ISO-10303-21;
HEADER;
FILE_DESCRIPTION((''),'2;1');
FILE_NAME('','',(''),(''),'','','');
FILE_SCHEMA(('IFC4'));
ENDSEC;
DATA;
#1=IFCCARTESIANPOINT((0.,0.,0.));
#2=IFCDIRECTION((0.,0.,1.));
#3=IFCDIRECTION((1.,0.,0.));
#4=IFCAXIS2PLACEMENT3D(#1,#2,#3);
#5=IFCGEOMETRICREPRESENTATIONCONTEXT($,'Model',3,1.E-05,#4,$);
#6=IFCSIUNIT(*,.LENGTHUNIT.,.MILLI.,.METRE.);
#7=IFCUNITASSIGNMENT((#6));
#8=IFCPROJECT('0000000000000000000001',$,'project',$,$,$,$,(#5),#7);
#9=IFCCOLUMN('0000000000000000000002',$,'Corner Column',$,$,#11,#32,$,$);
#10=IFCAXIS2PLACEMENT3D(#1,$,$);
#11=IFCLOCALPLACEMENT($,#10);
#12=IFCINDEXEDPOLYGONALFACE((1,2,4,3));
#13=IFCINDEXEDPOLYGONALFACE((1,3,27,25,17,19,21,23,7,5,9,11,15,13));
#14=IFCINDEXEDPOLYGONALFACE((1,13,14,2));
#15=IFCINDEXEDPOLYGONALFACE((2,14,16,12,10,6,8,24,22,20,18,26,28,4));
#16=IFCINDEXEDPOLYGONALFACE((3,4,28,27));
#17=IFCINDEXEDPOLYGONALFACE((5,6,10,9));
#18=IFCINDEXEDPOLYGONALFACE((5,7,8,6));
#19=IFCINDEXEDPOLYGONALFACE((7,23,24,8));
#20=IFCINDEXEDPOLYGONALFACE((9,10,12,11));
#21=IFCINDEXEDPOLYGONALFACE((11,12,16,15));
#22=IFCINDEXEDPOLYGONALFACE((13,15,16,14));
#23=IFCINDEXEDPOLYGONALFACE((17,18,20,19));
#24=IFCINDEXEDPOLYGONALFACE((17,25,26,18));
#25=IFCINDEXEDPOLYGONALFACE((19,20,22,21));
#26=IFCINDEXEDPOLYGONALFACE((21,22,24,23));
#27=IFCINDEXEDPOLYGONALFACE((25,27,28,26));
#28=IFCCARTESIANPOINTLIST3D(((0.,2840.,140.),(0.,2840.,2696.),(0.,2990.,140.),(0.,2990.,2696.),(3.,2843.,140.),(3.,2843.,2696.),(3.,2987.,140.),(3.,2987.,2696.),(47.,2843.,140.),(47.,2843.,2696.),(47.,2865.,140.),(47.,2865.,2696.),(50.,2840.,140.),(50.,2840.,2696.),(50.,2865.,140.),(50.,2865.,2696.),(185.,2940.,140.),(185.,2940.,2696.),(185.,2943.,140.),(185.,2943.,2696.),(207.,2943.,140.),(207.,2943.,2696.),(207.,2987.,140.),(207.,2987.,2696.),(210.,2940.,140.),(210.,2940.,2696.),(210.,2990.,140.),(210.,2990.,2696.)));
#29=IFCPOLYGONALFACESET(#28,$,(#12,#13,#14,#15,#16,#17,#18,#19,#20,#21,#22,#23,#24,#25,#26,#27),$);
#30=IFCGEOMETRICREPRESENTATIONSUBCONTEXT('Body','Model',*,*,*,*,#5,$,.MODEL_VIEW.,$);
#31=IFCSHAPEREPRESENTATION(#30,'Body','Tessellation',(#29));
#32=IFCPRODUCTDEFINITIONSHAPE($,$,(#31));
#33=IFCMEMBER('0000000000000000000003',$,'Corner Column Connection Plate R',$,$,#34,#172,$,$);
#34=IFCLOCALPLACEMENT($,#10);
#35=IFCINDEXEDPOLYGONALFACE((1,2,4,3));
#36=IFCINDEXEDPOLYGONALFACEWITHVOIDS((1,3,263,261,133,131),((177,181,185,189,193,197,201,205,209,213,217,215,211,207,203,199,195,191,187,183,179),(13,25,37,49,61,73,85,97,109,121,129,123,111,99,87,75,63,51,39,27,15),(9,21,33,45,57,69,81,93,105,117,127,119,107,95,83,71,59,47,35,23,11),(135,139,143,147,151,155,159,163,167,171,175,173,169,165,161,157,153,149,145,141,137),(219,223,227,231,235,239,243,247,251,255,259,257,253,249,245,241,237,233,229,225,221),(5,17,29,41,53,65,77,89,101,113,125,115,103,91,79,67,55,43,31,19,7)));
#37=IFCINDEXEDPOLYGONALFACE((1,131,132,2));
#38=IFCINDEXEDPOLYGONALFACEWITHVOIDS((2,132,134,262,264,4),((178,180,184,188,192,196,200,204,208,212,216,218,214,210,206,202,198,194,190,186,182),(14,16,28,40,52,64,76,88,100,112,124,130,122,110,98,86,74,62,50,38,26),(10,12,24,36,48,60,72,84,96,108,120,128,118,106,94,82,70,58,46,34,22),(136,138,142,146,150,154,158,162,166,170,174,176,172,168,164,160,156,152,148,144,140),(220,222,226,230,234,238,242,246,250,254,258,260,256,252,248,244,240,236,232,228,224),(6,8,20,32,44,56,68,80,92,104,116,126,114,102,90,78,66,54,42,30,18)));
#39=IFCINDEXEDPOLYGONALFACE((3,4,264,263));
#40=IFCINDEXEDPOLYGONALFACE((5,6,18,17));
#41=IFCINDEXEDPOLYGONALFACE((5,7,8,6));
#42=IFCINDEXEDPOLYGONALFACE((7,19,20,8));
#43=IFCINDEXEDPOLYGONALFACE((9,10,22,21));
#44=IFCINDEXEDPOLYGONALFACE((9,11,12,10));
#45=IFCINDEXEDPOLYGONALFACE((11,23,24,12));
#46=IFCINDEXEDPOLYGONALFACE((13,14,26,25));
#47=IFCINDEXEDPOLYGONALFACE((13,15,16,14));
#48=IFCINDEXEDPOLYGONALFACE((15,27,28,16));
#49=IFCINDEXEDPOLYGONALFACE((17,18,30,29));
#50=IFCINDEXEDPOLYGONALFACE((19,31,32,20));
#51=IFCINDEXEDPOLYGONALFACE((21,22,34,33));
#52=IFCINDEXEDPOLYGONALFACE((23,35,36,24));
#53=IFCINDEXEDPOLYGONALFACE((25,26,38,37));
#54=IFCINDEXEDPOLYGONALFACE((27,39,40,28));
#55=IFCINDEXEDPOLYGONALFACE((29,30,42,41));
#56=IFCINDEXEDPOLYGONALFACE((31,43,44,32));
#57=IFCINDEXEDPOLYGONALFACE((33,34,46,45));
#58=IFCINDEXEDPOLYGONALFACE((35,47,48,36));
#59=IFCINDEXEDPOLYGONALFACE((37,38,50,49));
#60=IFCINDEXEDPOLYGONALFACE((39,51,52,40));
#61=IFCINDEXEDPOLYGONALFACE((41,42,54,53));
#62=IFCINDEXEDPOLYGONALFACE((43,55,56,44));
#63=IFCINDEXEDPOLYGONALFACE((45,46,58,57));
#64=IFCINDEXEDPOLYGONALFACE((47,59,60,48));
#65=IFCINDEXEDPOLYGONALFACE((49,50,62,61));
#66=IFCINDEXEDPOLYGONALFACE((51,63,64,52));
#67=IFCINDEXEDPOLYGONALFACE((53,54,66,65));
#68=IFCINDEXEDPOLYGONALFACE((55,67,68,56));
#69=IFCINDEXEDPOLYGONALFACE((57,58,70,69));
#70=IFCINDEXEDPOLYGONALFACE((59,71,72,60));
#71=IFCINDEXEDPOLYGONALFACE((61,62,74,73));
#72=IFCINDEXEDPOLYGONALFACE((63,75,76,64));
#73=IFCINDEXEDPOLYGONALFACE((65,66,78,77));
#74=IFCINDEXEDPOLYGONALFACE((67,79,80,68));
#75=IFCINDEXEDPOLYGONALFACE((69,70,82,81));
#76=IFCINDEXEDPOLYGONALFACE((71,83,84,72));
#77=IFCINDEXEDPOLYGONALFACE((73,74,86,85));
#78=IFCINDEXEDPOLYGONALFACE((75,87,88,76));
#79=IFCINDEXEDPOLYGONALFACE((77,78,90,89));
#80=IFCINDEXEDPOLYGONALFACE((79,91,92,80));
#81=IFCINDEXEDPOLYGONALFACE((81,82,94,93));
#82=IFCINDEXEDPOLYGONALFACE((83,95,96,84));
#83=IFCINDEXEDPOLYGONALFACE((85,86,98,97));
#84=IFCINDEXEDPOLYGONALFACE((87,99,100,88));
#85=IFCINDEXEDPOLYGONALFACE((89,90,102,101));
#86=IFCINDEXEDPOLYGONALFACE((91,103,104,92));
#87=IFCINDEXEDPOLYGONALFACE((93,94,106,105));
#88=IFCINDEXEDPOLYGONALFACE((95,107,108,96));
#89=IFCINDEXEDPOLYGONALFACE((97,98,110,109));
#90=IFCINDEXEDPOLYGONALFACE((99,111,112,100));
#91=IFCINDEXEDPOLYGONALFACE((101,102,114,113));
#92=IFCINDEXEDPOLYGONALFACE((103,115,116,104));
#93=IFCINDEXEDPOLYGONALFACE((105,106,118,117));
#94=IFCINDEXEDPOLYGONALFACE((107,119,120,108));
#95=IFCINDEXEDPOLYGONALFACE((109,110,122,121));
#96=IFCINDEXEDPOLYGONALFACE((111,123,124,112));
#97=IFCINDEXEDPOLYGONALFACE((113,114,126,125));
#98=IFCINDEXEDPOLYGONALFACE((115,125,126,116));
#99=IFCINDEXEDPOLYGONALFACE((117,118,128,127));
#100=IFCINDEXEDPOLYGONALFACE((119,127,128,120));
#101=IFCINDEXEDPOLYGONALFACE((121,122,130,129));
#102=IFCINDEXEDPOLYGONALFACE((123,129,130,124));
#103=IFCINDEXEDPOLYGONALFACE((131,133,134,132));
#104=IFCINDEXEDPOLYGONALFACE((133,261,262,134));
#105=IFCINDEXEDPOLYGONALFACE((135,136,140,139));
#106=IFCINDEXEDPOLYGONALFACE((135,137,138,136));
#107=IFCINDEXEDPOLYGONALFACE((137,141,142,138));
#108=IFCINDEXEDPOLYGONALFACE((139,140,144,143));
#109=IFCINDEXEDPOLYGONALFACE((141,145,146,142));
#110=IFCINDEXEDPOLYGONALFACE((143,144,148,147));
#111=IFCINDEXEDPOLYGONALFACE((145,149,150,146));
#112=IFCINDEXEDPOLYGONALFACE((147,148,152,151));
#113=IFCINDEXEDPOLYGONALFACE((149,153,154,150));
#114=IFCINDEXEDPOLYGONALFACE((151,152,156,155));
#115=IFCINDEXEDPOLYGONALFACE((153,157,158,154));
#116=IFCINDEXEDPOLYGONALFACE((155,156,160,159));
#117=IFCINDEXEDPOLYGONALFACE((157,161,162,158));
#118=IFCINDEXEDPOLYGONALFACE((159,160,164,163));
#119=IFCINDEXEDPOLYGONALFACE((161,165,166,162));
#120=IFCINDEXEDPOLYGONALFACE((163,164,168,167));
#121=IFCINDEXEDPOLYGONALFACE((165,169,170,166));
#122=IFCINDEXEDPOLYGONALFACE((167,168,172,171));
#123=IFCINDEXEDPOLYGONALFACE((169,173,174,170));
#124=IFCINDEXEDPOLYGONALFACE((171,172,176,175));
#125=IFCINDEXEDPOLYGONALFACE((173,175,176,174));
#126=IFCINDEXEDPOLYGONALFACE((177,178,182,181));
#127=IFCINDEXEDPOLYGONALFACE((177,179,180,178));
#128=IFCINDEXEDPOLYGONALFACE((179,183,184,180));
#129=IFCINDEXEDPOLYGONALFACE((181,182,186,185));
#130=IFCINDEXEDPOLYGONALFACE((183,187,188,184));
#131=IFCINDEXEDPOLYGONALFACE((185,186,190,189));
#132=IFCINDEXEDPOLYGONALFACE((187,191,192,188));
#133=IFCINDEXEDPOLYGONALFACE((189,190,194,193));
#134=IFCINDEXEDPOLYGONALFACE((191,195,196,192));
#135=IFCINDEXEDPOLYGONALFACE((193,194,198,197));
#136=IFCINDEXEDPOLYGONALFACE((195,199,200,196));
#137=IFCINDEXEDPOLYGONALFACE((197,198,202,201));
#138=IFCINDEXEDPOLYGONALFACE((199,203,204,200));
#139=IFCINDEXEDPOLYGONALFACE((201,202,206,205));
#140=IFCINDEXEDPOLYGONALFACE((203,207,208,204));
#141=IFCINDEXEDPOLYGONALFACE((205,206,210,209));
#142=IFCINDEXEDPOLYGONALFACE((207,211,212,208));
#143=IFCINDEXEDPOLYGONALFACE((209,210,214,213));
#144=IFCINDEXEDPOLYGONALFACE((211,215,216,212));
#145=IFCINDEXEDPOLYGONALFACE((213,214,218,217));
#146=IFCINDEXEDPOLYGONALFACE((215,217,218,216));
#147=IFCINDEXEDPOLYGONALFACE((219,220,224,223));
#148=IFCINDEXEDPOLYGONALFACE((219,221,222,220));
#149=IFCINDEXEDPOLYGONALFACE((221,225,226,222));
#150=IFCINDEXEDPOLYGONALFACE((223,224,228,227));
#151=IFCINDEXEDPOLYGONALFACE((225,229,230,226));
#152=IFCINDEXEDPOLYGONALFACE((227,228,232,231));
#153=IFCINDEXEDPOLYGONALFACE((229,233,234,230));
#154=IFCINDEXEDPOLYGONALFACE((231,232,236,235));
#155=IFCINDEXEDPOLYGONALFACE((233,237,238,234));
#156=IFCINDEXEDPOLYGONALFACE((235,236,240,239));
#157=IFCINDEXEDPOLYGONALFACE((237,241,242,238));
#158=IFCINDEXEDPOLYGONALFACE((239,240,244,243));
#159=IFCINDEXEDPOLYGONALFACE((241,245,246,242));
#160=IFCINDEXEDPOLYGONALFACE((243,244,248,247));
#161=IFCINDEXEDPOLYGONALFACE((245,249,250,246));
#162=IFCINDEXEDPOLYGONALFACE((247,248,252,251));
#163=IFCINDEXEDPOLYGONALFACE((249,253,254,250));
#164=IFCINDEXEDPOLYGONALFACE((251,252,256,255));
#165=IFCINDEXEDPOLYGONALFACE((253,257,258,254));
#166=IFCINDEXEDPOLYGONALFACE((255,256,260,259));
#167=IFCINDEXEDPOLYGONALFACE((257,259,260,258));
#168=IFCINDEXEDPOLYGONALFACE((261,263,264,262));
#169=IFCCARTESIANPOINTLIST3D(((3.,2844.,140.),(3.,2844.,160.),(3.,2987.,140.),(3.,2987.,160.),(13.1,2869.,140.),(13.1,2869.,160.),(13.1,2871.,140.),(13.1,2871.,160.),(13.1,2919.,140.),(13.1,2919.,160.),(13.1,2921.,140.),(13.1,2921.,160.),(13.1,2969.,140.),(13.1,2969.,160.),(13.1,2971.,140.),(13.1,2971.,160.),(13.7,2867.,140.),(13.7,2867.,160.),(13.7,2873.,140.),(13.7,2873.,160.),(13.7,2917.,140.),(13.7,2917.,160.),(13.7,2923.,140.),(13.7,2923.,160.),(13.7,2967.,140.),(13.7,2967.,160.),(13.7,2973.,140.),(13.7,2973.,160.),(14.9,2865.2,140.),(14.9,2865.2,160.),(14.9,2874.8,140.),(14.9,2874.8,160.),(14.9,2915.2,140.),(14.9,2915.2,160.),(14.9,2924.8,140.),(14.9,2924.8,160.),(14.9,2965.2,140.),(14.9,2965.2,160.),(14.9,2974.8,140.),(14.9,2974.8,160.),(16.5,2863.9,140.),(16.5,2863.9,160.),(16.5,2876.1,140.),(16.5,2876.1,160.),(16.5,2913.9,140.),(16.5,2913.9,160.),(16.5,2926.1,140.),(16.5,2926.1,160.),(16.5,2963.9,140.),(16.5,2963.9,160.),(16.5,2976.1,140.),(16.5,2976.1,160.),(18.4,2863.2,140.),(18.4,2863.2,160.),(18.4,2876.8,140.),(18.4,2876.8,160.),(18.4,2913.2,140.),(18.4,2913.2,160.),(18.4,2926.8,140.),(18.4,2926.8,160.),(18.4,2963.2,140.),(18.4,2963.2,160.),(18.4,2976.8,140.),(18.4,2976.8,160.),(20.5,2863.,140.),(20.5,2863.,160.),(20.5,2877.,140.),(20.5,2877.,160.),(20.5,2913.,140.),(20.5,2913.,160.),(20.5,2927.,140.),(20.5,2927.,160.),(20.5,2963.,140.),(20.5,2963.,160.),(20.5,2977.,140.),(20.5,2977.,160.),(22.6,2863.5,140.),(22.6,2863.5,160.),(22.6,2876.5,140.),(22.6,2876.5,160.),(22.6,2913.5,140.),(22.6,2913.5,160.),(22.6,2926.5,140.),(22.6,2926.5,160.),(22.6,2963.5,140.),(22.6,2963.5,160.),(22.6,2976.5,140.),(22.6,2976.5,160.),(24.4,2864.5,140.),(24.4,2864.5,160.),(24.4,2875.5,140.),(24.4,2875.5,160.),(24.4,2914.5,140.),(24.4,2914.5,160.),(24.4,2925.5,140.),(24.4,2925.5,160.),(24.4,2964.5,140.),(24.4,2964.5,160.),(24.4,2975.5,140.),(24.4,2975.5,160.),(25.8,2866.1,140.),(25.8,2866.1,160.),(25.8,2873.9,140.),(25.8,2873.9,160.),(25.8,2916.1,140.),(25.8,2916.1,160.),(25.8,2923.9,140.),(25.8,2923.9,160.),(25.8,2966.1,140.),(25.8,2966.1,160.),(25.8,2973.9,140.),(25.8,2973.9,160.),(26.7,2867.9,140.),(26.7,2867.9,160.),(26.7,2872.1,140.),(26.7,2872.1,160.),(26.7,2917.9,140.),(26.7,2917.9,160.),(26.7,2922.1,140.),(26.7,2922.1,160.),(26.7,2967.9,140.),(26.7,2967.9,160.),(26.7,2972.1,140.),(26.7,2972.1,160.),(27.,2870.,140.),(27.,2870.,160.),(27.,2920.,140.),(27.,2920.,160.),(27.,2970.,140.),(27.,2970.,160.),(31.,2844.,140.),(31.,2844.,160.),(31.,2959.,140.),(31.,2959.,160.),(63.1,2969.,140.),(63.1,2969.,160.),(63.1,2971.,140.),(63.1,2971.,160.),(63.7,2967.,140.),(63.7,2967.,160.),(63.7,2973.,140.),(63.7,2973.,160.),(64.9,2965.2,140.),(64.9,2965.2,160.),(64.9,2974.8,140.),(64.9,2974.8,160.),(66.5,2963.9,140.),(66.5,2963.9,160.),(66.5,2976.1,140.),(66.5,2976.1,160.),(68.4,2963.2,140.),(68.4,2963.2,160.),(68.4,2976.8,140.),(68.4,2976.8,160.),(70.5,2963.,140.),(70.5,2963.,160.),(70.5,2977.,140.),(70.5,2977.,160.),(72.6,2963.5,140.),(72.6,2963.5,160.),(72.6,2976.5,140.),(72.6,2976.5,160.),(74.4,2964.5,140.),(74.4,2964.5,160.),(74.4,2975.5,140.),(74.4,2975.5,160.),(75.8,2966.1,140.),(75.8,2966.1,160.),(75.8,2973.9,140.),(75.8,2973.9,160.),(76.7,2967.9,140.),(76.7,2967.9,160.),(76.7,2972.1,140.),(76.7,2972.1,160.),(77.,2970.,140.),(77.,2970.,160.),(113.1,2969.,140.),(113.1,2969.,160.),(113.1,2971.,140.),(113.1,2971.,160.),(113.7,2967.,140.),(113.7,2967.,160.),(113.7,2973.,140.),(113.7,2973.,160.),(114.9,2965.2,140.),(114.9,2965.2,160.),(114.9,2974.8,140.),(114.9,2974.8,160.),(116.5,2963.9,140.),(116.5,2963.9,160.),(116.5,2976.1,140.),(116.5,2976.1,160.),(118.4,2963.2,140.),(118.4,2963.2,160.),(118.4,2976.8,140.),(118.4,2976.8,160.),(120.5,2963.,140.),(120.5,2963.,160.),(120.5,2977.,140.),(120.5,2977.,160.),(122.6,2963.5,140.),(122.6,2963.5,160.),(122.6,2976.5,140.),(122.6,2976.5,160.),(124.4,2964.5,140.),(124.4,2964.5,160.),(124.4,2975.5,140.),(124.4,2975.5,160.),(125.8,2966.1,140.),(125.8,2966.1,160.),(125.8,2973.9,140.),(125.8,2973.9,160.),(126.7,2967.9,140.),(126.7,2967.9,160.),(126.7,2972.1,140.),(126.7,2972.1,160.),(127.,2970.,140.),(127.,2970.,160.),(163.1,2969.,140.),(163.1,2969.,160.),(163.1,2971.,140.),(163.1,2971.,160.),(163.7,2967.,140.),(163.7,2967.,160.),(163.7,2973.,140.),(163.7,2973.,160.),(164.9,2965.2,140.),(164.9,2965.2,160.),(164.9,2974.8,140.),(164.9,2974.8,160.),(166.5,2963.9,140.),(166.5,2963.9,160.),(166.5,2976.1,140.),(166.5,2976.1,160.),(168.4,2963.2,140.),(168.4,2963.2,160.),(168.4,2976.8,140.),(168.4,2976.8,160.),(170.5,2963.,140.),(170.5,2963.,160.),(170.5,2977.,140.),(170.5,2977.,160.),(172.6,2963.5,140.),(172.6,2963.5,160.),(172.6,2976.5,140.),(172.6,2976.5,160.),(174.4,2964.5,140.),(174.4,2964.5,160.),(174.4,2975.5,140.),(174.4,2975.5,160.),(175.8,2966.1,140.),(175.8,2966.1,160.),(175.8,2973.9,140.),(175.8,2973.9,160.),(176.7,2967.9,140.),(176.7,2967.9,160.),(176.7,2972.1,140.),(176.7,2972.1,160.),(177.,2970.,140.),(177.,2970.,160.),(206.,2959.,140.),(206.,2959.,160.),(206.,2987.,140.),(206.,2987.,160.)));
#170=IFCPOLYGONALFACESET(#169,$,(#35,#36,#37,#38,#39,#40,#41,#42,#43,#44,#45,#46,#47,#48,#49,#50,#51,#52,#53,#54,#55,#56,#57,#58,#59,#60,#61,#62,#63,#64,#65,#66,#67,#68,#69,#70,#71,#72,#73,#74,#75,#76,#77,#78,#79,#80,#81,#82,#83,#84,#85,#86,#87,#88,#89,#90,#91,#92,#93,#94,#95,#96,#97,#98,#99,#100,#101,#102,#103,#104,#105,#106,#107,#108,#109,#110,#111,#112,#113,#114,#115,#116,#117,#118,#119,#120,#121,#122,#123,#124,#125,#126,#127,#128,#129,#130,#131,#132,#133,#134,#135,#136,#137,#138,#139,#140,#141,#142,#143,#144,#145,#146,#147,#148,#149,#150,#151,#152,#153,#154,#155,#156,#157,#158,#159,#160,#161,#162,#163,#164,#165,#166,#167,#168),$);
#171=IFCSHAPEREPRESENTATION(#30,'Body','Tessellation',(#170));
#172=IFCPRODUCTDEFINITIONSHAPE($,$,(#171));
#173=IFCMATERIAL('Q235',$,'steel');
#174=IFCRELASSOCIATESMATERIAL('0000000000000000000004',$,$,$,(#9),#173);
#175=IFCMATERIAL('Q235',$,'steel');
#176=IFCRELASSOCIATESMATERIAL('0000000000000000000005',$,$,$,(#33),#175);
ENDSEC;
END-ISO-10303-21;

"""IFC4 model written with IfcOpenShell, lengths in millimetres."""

from ifc_helpers import new_model, si_unit, frame, origin_with_axes, origin_2d, place, context, subcontext, project, line, indexed_curve, circle_curve, outline, extrude, material, element, save


model = new_model("IFC4")

# Units and contexts
model_context = context("Model", 3, precision=1e-05, world=origin_with_axes())
body_context = subcontext(model_context, "Body", "Model", "MODEL_VIEW")
ifc_project = project(units=[si_unit("LENGTHUNIT", "METRE", prefix="MILLI")], contexts=[model_context])

# Column
ifc_material_1 = material(Name="Q235", Category="steel")
column_placement = place(None, frame((0.0, 2990.0, 140.0), z_axis=(0.0, 0.0, 1.0), x_axis=(0.0, -1.0, 0.0)))
element("IfcColumn", 1, at=column_placement, material=ifc_material_1, Name="Corner Column", context=body_context, shape_type="SweptSolid", body=[
    extrude(outline(indexed_curve([(0.0, 0.0), (0.0, 210.0), (50.0, 210.0), (50.0, 185.0), (47.0, 185.0), (47.0, 207.0), (3.0, 207.0), (3.0, 3.0), (147.0, 3.0), (147.0, 47.0), (125.0, 47.0), (125.0, 50.0), (150.0, 50.0), (150.0, 0.0), (0.0, 0.0)], segments=[line(1, 2, 3, 4, 5, 6, 7, 8, 9, 10, 11, 12, 13, 14, 15, 1)])), origin_with_axes(), (0.0, 0.0, 1.0), 2556.0),
])

# Member, openings
ifc_material_2 = material(Name="Q235", Category="steel")
member_1_placement = place(None, frame((3.0, 2987.0, 140.0), z_axis=(0.0, 0.0, 1.0), x_axis=(1.0, 0.0, 0.0)))
member_1 = element("IfcMember", 2, at=member_1_placement, material=ifc_material_2, Name="Corner Column Connection Plate R", context=body_context, shape_type="SweptSolid", body=[
    extrude(outline(indexed_curve([(0.0, 0.0), (203.0, 0.0), (203.0, -28.0), (28.0, -28.0), (28.0, -143.0), (0.0, -143.0), (0.0, 0.0)], segments=[line(1, 2, 3, 4, 5, 6, 7, 1)])), origin_with_axes(), (0.0, 0.0, 1.0), 20.0),
])
opening_1_placement = place(member_1_placement, frame((17.0, -17.0, 0.0), z_axis=(0.0, 0.0, 1.0), x_axis=(1.0, 0.0, 0.0)))
element("IfcOpeningElement", 3, at=opening_1_placement, cuts=member_1, context=body_context, shape_type="SweptSolid", body=[
    extrude(outline(circle_curve(origin_2d(), 7.0)), origin_with_axes(), (0.0, 0.0, 1.0), 20.0),
])
opening_2_placement = place(member_1_placement, frame((67.0, -17.0, 0.0), z_axis=(0.0, 0.0, 1.0), x_axis=(1.0, 0.0, 0.0)))
element("IfcOpeningElement", 4, at=opening_2_placement, cuts=member_1, context=body_context, shape_type="SweptSolid", body=[
    extrude(outline(circle_curve(origin_2d(), 7.0)), origin_with_axes(), (0.0, 0.0, 1.0), 20.0),
])
opening_3_placement = place(member_1_placement, frame((117.0, -17.0, 0.0), z_axis=(0.0, 0.0, 1.0), x_axis=(1.0, 0.0, 0.0)))
element("IfcOpeningElement", 5, at=opening_3_placement, cuts=member_1, context=body_context, shape_type="SweptSolid", body=[
    extrude(outline(circle_curve(origin_2d(), 7.0)), origin_with_axes(), (0.0, 0.0, 1.0), 20.0),
])
opening_4_placement = place(member_1_placement, frame((167.0, -17.0, 0.0), z_axis=(0.0, 0.0, 1.0), x_axis=(1.0, 0.0, 0.0)))
element("IfcOpeningElement", 6, at=opening_4_placement, cuts=member_1, context=body_context, shape_type="SweptSolid", body=[
    extrude(outline(circle_curve(origin_2d(), 7.0)), origin_with_axes(), (0.0, 0.0, 1.0), 20.0),
])
opening_5_placement = place(member_1_placement, frame((17.0, -67.0, 0.0), z_axis=(0.0, 0.0, 1.0), x_axis=(1.0, 0.0, 0.0)))
element("IfcOpeningElement", 7, at=opening_5_placement, cuts=member_1, context=body_context, shape_type="SweptSolid", body=[
    extrude(outline(circle_curve(origin_2d(), 7.0)), origin_with_axes(), (0.0, 0.0, 1.0), 20.0),
])
opening_6_placement = place(member_1_placement, frame((17.0, -117.0, 0.0), z_axis=(0.0, 0.0, 1.0), x_axis=(1.0, 0.0, 0.0)))
element("IfcOpeningElement", 8, at=opening_6_placement, cuts=member_1, context=body_context, shape_type="SweptSolid", body=[
    extrude(outline(circle_curve(origin_2d(), 7.0)), origin_with_axes(), (0.0, 0.0, 1.0), 20.0),
])

save(model, "model.ifc")
